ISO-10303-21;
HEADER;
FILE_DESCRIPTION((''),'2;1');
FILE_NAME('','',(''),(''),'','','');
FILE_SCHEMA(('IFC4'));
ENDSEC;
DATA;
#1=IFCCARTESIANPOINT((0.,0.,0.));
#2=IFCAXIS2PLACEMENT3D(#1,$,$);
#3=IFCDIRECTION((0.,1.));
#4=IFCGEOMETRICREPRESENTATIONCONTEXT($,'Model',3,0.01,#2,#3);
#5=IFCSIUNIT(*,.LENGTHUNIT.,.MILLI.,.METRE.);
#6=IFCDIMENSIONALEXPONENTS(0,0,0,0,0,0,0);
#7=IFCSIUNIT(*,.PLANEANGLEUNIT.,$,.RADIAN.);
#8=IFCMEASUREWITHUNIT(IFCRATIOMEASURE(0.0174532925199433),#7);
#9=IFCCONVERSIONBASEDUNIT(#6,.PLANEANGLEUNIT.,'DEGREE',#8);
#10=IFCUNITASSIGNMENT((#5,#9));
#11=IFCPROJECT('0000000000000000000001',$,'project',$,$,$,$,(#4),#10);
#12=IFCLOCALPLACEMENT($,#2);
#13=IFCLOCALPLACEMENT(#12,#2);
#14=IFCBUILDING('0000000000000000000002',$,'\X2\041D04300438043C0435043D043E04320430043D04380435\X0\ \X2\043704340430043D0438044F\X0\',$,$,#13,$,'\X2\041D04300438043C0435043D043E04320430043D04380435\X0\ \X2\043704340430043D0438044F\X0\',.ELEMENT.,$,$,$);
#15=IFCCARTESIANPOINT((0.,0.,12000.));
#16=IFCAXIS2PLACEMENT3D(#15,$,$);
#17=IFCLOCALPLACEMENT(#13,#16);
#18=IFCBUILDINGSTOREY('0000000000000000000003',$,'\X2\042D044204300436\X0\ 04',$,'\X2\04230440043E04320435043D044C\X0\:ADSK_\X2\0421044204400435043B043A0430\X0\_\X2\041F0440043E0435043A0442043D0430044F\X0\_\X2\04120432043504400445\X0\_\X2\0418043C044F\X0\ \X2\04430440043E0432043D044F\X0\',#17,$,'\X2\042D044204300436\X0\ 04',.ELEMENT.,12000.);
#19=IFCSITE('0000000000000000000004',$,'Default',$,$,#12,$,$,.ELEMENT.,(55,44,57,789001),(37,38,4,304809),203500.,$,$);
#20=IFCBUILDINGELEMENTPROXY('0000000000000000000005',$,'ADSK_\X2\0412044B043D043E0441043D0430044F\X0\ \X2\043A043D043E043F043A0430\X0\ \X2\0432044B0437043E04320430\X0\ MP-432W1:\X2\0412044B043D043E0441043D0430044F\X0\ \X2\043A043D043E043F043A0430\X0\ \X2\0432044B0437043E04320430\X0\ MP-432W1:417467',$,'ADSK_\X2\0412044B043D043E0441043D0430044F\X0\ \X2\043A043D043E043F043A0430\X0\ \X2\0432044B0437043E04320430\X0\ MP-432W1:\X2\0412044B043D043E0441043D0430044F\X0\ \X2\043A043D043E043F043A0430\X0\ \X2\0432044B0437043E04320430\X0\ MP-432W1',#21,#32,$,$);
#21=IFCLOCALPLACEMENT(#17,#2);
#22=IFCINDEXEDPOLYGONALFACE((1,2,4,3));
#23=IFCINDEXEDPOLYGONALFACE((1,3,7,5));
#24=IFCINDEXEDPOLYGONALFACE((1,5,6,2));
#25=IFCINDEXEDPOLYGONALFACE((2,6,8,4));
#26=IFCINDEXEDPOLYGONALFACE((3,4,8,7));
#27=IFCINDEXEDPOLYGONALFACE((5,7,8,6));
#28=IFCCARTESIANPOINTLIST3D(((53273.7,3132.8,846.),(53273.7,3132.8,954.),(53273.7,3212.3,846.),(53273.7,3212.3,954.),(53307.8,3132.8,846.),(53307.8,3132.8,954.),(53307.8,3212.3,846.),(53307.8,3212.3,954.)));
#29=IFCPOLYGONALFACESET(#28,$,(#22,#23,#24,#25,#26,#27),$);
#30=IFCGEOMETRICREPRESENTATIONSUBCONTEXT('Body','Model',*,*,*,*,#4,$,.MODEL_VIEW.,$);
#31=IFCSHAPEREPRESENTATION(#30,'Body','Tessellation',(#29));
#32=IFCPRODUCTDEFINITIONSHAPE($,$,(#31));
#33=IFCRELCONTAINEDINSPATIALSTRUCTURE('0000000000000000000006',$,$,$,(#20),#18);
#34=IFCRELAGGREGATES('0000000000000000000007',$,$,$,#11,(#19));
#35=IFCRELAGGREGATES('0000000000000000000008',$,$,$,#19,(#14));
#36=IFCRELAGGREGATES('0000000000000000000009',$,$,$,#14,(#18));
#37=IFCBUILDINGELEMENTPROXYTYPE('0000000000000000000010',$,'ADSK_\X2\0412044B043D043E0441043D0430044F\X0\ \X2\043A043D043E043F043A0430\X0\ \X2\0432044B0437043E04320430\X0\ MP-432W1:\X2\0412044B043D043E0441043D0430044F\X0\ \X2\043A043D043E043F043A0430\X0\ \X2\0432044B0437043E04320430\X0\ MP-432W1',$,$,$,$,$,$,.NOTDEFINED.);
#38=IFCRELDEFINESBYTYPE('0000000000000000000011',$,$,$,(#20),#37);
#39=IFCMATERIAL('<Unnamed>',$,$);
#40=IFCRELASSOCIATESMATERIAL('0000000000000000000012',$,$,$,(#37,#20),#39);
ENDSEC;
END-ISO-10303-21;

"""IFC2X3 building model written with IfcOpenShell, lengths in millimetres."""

from ifc_helpers import new_model, entity, si_unit, converted_unit, direction, frame, origin, origin_2d_with_axis, place, context, subcontext, project, spatial, rectangle, extrude, source, transform, mapped, material, type_object, type_shapes, element, save


model = new_model("IFC2X3")

# Units and contexts
model_context = context("Model", 3, precision=0.01, world=origin(), true_north=direction((0.0, 1.0)))
body_context = subcontext(model_context, "Body", "Model", "MODEL_VIEW")
ifc_project = project(units=[si_unit("LENGTHUNIT", "METRE", prefix="MILLI"), converted_unit("PLANEANGLEUNIT", "DEGREE", entity("IfcRatioMeasure", 0.0174532925199433), si_unit("PLANEANGLEUNIT", "RADIAN"), dimensions=[0, 0, 0, 0, 0, 0, 0])], contexts=[model_context])

# Site, building, storey
site_placement = place(None, origin())
site = spatial("IfcSite", under=ifc_project, at=site_placement, Name="Default", CompositionType="ELEMENT", RefLatitude=(55, 44, 57, 789001), RefLongitude=(37, 38, 4, 304809), RefElevation=203500.0)
building_placement = place(site_placement, origin())
building = spatial("IfcBuilding", under=site, at=building_placement, Name="Наименование здания", LongName="Наименование здания", CompositionType="ELEMENT")
storey_placement = place(building_placement, frame((0.0, 0.0, 12000.0)))
storey = spatial("IfcBuildingStorey", under=building, at=storey_placement, Name="Этаж 04", ObjectType="Уровень:ADSK_Стрелка_Проектная_Вверх_Имя уровня", LongName="Этаж 04", CompositionType="ELEMENT", Elevation=12000.0)

# Building element proxy
ifc_material = material(Name="<Unnamed>")
shared_shape_1 = source(origin(), body_context, "Body", "SweptSolid", [
    extrude(rectangle(XDim=79.5, YDim=34.1, at=origin_2d_with_axis()), frame((0.0, 15.0, -54.0), z_axis=(0.0, 0.0, 1.0), x_axis=(-1.0, 0.0, 0.0)), (0.0, 0.0, 1.0), 108.0),
])
building_element_proxy_type_1 = type_object("IfcBuildingElementProxyType", Name="ADSK_Выносная кнопка вызова MP-432W1:Выносная кнопка вызова MP-432W1", PredefinedType="NOTDEFINED", material=ifc_material)
type_shapes(building_element_proxy_type_1, [shared_shape_1])
for number, where, z_axis, x_axis, name in (
    (1, (53275.8, 3172.5, 900.0), (0.0, 0.0, 1.0), (0.0, -1.0, 0.0), "ADSK_Выносная кнопка вызова MP-432W1:Выносная кнопка вызова MP-432W1:417467"),
):
    element("IfcBuildingElementProxy", number, at=place(storey_placement, frame(where, z_axis=z_axis, x_axis=x_axis)), inside=storey, type_object=building_element_proxy_type_1, material=ifc_material, Name=name, ObjectType="ADSK_Выносная кнопка вызова MP-432W1:Выносная кнопка вызова MP-432W1", context=body_context, shape_type="MappedRepresentation", body=[
        mapped(shared_shape_1, transform((0.0, 0.0, 0.0), scale=1.0)),
    ])

save(model, "model.ifc")
